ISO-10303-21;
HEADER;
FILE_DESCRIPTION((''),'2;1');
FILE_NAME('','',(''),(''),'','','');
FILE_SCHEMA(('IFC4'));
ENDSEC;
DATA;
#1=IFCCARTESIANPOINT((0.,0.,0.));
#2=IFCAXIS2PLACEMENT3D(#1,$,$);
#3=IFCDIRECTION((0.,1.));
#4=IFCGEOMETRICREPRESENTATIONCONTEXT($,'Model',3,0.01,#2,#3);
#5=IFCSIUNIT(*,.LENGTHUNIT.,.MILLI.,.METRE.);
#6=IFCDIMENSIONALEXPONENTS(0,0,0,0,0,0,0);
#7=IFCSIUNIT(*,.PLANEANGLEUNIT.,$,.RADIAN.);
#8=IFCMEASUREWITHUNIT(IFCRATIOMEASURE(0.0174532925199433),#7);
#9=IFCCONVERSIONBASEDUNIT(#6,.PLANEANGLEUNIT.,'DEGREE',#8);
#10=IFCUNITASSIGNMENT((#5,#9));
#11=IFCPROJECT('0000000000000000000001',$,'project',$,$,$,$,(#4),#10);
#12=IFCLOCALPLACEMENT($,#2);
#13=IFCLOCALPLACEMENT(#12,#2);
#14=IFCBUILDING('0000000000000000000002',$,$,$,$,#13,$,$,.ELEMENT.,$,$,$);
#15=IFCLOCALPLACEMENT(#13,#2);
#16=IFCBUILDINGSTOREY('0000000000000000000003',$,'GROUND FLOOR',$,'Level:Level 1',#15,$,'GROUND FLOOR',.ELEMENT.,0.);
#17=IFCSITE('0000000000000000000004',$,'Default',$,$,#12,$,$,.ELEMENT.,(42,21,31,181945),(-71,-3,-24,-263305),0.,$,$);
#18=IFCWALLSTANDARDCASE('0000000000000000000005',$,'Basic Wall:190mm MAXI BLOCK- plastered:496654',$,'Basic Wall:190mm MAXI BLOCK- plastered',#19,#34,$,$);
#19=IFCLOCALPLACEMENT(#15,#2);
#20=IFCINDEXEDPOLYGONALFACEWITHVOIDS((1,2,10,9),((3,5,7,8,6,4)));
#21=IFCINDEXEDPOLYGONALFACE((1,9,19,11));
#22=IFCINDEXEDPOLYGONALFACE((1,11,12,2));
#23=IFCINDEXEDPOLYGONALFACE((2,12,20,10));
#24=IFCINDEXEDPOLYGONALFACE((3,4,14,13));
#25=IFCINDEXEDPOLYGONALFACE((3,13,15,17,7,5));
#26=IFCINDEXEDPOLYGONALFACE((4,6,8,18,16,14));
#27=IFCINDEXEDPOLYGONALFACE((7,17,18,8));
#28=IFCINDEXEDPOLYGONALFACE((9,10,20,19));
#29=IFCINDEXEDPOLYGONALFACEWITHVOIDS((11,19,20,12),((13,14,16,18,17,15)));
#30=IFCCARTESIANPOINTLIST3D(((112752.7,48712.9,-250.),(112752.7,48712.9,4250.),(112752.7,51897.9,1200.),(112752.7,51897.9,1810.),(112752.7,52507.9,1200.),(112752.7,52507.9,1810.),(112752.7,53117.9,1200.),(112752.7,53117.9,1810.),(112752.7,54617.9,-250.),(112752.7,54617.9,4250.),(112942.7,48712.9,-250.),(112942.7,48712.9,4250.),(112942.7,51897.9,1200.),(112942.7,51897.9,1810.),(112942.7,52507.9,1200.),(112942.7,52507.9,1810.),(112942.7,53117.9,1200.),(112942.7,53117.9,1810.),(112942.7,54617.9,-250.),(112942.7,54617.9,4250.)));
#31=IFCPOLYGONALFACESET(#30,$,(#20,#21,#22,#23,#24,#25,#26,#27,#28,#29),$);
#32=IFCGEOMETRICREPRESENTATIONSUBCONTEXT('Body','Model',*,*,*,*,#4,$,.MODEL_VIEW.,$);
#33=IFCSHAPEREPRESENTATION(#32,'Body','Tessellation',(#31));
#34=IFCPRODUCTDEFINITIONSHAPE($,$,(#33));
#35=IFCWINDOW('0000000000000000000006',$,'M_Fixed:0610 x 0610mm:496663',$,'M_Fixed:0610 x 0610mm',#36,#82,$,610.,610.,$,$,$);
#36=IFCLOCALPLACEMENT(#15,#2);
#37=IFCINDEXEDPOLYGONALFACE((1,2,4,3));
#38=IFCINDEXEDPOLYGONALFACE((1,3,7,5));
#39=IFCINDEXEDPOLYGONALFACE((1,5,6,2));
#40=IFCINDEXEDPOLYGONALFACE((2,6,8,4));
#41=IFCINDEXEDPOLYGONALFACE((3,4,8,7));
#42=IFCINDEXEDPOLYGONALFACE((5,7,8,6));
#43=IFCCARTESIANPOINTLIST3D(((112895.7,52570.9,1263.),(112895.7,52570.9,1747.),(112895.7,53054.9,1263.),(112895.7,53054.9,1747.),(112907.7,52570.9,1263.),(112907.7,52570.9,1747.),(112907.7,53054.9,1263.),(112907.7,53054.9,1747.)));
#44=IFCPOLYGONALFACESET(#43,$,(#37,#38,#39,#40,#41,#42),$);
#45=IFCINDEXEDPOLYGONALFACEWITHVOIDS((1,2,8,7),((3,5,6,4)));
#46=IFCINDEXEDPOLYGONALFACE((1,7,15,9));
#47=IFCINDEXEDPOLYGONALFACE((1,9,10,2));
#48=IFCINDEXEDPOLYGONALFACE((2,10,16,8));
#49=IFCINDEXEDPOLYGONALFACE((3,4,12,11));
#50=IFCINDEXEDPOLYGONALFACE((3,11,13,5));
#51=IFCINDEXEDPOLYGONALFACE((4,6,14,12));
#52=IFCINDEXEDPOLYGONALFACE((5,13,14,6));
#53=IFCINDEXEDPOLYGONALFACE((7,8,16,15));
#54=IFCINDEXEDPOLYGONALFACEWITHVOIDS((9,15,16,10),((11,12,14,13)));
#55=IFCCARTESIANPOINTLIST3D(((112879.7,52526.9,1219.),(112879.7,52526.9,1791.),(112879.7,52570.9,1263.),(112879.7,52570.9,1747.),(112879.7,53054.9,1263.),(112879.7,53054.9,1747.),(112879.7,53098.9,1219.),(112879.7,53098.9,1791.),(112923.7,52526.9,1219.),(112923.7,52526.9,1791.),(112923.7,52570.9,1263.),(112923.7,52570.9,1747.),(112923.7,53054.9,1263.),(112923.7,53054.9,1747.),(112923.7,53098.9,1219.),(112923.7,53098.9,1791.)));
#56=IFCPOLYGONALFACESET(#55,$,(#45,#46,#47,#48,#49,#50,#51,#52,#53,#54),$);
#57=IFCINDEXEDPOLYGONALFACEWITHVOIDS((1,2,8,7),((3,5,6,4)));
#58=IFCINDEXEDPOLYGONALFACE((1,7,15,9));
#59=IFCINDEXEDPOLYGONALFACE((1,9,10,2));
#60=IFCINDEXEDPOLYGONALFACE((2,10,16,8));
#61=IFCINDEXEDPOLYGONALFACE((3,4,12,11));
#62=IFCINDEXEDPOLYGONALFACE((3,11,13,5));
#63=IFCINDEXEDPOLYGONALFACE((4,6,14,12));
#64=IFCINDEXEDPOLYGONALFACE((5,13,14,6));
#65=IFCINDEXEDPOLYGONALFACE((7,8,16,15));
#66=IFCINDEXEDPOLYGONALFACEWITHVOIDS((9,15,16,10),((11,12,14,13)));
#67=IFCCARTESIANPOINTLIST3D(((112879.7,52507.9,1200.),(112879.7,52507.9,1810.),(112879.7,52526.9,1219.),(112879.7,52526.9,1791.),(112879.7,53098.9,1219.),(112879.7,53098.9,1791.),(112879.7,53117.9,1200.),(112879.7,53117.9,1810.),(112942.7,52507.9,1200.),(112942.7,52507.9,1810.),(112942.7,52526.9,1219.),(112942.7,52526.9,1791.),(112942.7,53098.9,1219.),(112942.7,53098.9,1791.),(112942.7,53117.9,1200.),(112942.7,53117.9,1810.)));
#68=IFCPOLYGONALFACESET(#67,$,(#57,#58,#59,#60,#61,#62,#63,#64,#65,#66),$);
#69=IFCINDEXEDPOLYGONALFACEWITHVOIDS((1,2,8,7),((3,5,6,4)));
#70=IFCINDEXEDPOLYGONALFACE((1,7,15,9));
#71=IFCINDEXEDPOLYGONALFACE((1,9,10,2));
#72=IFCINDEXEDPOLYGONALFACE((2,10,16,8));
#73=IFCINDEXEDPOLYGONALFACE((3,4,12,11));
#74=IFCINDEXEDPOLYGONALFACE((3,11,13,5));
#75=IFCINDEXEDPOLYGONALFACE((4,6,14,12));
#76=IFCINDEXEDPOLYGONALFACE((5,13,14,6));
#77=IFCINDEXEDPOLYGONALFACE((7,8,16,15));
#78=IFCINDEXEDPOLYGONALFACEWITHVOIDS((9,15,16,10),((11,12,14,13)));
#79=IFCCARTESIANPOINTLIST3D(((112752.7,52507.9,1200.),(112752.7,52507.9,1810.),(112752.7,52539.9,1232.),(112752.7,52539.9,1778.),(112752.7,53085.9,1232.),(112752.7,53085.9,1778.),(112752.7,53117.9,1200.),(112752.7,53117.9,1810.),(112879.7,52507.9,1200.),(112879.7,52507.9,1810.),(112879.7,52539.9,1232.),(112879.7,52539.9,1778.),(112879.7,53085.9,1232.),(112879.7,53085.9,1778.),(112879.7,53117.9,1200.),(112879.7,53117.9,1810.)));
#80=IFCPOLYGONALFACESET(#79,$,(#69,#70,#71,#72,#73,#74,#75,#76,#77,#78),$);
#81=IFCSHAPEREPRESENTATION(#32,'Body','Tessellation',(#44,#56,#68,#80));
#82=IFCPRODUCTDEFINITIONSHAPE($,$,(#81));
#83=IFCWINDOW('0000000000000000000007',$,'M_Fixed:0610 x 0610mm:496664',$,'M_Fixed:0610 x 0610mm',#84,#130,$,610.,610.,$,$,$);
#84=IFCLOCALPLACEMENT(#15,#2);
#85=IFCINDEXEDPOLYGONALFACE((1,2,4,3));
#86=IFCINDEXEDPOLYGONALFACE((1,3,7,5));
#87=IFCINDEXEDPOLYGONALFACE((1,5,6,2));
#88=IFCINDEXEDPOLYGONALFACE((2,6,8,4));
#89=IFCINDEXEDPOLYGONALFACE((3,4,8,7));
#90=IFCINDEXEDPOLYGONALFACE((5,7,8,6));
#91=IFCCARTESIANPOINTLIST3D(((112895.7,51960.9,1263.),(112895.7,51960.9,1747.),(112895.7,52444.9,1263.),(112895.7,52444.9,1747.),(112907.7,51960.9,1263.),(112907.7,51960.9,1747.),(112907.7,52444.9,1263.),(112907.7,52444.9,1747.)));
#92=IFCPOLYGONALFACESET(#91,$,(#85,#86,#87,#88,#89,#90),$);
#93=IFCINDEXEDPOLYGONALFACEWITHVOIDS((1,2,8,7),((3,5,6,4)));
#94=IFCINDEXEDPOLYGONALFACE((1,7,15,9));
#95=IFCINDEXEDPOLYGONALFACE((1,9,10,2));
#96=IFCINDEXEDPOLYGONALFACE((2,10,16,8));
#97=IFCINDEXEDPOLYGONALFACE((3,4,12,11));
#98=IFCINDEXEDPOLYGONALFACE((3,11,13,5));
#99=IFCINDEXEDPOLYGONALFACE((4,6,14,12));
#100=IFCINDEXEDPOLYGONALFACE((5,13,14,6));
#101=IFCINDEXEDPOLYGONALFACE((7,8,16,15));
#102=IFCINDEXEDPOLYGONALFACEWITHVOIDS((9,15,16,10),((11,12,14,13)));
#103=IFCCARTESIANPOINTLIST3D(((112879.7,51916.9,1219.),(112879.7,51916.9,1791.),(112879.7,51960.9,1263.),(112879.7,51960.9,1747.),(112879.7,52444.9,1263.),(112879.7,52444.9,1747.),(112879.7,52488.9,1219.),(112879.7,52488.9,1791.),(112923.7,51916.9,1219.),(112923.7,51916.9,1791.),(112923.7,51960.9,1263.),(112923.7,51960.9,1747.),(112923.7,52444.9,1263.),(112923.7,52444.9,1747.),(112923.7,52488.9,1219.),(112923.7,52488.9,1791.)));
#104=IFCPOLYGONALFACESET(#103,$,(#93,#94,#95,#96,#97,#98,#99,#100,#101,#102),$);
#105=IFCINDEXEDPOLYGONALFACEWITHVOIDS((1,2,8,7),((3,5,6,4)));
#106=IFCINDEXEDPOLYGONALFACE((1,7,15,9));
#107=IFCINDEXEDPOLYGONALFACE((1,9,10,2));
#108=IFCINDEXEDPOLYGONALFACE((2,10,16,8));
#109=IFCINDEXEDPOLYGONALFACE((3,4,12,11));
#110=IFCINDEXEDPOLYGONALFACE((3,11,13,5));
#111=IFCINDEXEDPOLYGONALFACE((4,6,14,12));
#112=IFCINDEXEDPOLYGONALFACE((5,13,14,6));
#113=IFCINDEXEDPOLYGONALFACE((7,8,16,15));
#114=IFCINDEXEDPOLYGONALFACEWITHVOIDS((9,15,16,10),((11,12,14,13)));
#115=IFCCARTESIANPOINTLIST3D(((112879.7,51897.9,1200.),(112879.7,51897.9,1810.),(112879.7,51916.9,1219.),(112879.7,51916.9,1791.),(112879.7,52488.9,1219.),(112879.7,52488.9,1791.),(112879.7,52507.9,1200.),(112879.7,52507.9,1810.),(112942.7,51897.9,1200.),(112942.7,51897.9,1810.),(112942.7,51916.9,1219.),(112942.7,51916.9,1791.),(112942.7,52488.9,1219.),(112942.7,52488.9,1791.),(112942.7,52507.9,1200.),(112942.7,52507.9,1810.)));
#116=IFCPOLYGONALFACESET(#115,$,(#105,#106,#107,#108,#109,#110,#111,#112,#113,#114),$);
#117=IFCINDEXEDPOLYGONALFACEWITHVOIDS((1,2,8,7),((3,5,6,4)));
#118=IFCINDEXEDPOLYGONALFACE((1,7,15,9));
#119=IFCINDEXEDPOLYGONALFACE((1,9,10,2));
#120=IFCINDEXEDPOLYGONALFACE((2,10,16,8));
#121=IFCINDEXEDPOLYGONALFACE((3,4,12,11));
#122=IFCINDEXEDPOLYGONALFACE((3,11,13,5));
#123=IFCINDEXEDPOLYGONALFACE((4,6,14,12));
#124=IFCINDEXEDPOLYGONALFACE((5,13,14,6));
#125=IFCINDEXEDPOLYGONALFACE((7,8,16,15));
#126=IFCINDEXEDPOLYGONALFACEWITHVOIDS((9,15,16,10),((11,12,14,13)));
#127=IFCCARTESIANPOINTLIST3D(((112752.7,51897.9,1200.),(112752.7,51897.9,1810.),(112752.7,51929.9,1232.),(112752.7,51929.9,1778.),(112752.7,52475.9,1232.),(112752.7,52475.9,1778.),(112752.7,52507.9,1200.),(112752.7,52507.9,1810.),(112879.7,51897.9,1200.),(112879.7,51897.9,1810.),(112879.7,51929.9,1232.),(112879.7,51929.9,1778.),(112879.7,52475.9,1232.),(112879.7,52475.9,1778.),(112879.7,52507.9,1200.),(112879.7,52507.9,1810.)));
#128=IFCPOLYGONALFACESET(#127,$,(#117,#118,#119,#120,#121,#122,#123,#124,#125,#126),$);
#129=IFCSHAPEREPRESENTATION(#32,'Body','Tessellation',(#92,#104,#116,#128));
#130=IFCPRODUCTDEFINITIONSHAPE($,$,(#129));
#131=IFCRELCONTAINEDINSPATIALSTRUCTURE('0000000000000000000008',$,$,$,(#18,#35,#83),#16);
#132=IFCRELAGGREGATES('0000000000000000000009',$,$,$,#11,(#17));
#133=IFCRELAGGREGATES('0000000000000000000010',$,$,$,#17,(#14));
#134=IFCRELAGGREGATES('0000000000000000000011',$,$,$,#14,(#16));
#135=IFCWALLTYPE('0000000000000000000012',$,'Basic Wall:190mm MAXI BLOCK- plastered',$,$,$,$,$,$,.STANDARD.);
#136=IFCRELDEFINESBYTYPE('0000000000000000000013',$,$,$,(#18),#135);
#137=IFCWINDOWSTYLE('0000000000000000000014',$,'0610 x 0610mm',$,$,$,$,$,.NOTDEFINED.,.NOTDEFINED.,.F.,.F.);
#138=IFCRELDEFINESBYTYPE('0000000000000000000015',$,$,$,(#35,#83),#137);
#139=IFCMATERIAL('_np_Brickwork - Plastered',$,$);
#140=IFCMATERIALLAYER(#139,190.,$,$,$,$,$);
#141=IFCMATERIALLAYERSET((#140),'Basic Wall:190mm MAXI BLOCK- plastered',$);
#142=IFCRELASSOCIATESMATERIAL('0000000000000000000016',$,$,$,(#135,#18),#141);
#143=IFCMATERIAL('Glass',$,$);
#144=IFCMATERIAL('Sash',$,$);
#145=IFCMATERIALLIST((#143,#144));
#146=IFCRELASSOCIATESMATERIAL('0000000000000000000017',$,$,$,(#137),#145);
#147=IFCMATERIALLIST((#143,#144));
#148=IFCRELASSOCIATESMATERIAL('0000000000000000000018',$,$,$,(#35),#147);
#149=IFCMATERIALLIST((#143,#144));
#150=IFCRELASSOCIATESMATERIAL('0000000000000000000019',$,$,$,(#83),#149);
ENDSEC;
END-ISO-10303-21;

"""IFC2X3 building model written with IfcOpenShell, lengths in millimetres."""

from ifc_helpers import new_model, entity, si_unit, converted_unit, direction, frame, frame_2d, origin, place, context, subcontext, project, spatial, polyline, rectangle, outline, extrude, source, transform, mapped, material, material_list, layer, layer_set, layer_usage, type_object, type_shapes, element, fill, save


model = new_model("IFC2X3")

# Units and contexts
model_context = context("Model", 3, precision=0.01, world=origin(), true_north=direction((0.0, 1.0)))
body_context = subcontext(model_context, "Body", "Model", "MODEL_VIEW")
ifc_project = project(units=[si_unit("LENGTHUNIT", "METRE", prefix="MILLI"), converted_unit("PLANEANGLEUNIT", "DEGREE", entity("IfcRatioMeasure", 0.0174532925199433), si_unit("PLANEANGLEUNIT", "RADIAN"), dimensions=[0, 0, 0, 0, 0, 0, 0])], contexts=[model_context])

# Site, building, storey
site_placement = place(None, origin())
site = spatial("IfcSite", under=ifc_project, at=site_placement, Name="Default", CompositionType="ELEMENT", RefLatitude=(42, 21, 31, 181945), RefLongitude=(-71, -3, -24, -263305), RefElevation=0.0)
building_placement = place(site_placement, origin())
building = spatial("IfcBuilding", under=site, at=building_placement, CompositionType="ELEMENT")
storey_placement = place(building_placement, origin())
storey = spatial("IfcBuildingStorey", under=building, at=storey_placement, Name="GROUND FLOOR", ObjectType="Level:Level 1", LongName="GROUND FLOOR", CompositionType="ELEMENT", Elevation=0.0)

# Wall, openings, windows
ifc_material_1 = material(Name="_np_Brickwork - Plastered")
ifc_layer = layer(ifc_material_1, 190.0)
ifc_layer_set = layer_set([ifc_layer], Name="Basic Wall:190mm MAXI BLOCK- plastered")
wall_type = type_object("IfcWallType", Name="Basic Wall:190mm MAXI BLOCK- plastered", PredefinedType="STANDARD", material=ifc_layer_set)
ifc_material_2 = material(Name="Glass")
ifc_material_3 = material(Name="Sash")
ifc_material_list_1 = material_list([ifc_material_2, ifc_material_3])
window_style = type_object("IfcWindowStyle", Name="0610 x 0610mm", ConstructionType="NOTDEFINED", OperationType="NOTDEFINED", ParameterTakesPrecedence=False, Sizeable=False, material=ifc_material_list_1)
shared_shape_1 = source(origin(), body_context, "Body", "SweptSolid", [
    extrude(rectangle(XDim=12.0, YDim=484.0, at=frame_2d((0.0, 0.0), x_axis=(1.0, 0.0))), frame((305.0, 149.0, 63.0), z_axis=(0.0, 0.0, 1.0), x_axis=(0.0, -1.0, 0.0)), (0.0, 0.0, 1.0), 484.0),
    extrude(outline(polyline([(-286.0, -286.0), (286.0, -286.0), (286.0, 286.0), (-286.0, 286.0), (-286.0, -286.0)]), holes=[polyline([(-242.0, -242.0), (-242.0, 242.0), (242.0, 242.0), (242.0, -242.0), (-242.0, -242.0)])]), frame((305.0, 127.0, 305.0), z_axis=(0.0, 1.0, 0.0), x_axis=(1.0, 0.0, 0.0)), (0.0, 0.0, 1.0), 44.0),
    extrude(outline(polyline([(-305.0, -305.0), (305.0, -305.0), (305.0, 305.0), (-305.0, 305.0), (-305.0, -305.0)]), holes=[polyline([(-286.0, -286.0), (-286.0, 286.0), (286.0, 286.0), (286.0, -286.0), (-286.0, -286.0)])]), frame((305.0, 127.0, 305.0), z_axis=(0.0, 1.0, 0.0), x_axis=(1.0, 0.0, 0.0)), (0.0, 0.0, 1.0), 63.0),
    extrude(outline(polyline([(-305.0, -305.0), (305.0, -305.0), (305.0, 305.0), (-305.0, 305.0), (-305.0, -305.0)]), holes=[polyline([(-273.0, -273.0), (-273.0, 273.0), (273.0, 273.0), (273.0, -273.0), (-273.0, -273.0)])]), frame((305.0, 0.0, 305.0), z_axis=(0.0, 1.0, 0.0), x_axis=(1.0, 0.0, 0.0)), (0.0, 0.0, 1.0), 127.0),
])
type_shapes(window_style, [shared_shape_1])
ifc_layer_usage_1 = layer_usage(ifc_layer_set, "AXIS2", "NEGATIVE", 95.0)
wall_1_placement = place(storey_placement, frame((112847.7, 48712.9, -250.0), z_axis=(0.0, 0.0, 1.0), x_axis=(0.0, 1.0, 0.0)))
wall_1 = element("IfcWallStandardCase", 1, at=wall_1_placement, inside=storey, type_object=wall_type, material=ifc_layer_usage_1, Name="Basic Wall:190mm MAXI BLOCK- plastered:496654", ObjectType="Basic Wall:190mm MAXI BLOCK- plastered", context=body_context, shape_type="SweptSolid", body=[
    extrude(rectangle(XDim=5905.0, YDim=190.0, at=frame_2d((2952.5, 0.0), x_axis=(-1.0, 0.0))), origin(), (0.0, 0.0, 1.0), 4500.0),
])
opening_1_placement = place(wall_1_placement, frame((4405.0, 95.0, 1450.0)))
opening_1 = element("IfcOpeningElement", 2, at=opening_1_placement, cuts=wall_1, ObjectType="Opening", context=body_context, shape_type="SweptSolid", body=[
    extrude(rectangle(XDim=610.0, YDim=610.0, at=frame_2d((305.0, 305.0), x_axis=(1.0, 0.0))), frame((0.0, 0.0, 0.0), z_axis=(0.0, -1.0, 0.0), x_axis=(0.0, 0.0, 1.0)), (0.0, 0.0, 1.0), 190.0),
])
opening_2_placement = place(wall_1_placement, frame((3795.0, 95.0, 1450.0)))
opening_2 = element("IfcOpeningElement", 3, at=opening_2_placement, cuts=wall_1, ObjectType="Opening", context=body_context, shape_type="SweptSolid", body=[
    extrude(rectangle(XDim=610.0, YDim=610.0, at=frame_2d((305.0, 305.0), x_axis=(1.0, 0.0))), frame((0.0, 0.0, 0.0), z_axis=(0.0, -1.0, 0.0), x_axis=(0.0, 0.0, 1.0)), (0.0, 0.0, 1.0), 190.0),
])
ifc_material_list_2 = material_list([ifc_material_2, ifc_material_3])
window_1_placement = place(opening_1_placement, frame((0.0, 0.0, 0.0), z_axis=(0.0, 0.0, 1.0), x_axis=(-1.0, 0.0, 0.0)))
window_1 = element("IfcWindow", 4, at=window_1_placement, inside=storey, type_object=window_style, material=ifc_material_list_2, Name="M_Fixed:0610 x 0610mm:496663", ObjectType="M_Fixed:0610 x 0610mm", OverallHeight=610.0, OverallWidth=610.0, context=body_context, shape_type="MappedRepresentation", body=[
    mapped(shared_shape_1, transform((0.0, 0.0, 0.0), scale=1.0)),
])
fill(opening_1, window_1)
ifc_material_list_3 = material_list([ifc_material_2, ifc_material_3])
window_2_placement = place(opening_2_placement, frame((0.0, 0.0, 0.0), z_axis=(0.0, 0.0, 1.0), x_axis=(-1.0, 0.0, 0.0)))
window_2 = element("IfcWindow", 5, at=window_2_placement, inside=storey, type_object=window_style, material=ifc_material_list_3, Name="M_Fixed:0610 x 0610mm:496664", ObjectType="M_Fixed:0610 x 0610mm", OverallHeight=610.0, OverallWidth=610.0, context=body_context, shape_type="MappedRepresentation", body=[
    mapped(shared_shape_1, transform((0.0, 0.0, 0.0), scale=1.0)),
])
fill(opening_2, window_2)

save(model, "model.ifc")
